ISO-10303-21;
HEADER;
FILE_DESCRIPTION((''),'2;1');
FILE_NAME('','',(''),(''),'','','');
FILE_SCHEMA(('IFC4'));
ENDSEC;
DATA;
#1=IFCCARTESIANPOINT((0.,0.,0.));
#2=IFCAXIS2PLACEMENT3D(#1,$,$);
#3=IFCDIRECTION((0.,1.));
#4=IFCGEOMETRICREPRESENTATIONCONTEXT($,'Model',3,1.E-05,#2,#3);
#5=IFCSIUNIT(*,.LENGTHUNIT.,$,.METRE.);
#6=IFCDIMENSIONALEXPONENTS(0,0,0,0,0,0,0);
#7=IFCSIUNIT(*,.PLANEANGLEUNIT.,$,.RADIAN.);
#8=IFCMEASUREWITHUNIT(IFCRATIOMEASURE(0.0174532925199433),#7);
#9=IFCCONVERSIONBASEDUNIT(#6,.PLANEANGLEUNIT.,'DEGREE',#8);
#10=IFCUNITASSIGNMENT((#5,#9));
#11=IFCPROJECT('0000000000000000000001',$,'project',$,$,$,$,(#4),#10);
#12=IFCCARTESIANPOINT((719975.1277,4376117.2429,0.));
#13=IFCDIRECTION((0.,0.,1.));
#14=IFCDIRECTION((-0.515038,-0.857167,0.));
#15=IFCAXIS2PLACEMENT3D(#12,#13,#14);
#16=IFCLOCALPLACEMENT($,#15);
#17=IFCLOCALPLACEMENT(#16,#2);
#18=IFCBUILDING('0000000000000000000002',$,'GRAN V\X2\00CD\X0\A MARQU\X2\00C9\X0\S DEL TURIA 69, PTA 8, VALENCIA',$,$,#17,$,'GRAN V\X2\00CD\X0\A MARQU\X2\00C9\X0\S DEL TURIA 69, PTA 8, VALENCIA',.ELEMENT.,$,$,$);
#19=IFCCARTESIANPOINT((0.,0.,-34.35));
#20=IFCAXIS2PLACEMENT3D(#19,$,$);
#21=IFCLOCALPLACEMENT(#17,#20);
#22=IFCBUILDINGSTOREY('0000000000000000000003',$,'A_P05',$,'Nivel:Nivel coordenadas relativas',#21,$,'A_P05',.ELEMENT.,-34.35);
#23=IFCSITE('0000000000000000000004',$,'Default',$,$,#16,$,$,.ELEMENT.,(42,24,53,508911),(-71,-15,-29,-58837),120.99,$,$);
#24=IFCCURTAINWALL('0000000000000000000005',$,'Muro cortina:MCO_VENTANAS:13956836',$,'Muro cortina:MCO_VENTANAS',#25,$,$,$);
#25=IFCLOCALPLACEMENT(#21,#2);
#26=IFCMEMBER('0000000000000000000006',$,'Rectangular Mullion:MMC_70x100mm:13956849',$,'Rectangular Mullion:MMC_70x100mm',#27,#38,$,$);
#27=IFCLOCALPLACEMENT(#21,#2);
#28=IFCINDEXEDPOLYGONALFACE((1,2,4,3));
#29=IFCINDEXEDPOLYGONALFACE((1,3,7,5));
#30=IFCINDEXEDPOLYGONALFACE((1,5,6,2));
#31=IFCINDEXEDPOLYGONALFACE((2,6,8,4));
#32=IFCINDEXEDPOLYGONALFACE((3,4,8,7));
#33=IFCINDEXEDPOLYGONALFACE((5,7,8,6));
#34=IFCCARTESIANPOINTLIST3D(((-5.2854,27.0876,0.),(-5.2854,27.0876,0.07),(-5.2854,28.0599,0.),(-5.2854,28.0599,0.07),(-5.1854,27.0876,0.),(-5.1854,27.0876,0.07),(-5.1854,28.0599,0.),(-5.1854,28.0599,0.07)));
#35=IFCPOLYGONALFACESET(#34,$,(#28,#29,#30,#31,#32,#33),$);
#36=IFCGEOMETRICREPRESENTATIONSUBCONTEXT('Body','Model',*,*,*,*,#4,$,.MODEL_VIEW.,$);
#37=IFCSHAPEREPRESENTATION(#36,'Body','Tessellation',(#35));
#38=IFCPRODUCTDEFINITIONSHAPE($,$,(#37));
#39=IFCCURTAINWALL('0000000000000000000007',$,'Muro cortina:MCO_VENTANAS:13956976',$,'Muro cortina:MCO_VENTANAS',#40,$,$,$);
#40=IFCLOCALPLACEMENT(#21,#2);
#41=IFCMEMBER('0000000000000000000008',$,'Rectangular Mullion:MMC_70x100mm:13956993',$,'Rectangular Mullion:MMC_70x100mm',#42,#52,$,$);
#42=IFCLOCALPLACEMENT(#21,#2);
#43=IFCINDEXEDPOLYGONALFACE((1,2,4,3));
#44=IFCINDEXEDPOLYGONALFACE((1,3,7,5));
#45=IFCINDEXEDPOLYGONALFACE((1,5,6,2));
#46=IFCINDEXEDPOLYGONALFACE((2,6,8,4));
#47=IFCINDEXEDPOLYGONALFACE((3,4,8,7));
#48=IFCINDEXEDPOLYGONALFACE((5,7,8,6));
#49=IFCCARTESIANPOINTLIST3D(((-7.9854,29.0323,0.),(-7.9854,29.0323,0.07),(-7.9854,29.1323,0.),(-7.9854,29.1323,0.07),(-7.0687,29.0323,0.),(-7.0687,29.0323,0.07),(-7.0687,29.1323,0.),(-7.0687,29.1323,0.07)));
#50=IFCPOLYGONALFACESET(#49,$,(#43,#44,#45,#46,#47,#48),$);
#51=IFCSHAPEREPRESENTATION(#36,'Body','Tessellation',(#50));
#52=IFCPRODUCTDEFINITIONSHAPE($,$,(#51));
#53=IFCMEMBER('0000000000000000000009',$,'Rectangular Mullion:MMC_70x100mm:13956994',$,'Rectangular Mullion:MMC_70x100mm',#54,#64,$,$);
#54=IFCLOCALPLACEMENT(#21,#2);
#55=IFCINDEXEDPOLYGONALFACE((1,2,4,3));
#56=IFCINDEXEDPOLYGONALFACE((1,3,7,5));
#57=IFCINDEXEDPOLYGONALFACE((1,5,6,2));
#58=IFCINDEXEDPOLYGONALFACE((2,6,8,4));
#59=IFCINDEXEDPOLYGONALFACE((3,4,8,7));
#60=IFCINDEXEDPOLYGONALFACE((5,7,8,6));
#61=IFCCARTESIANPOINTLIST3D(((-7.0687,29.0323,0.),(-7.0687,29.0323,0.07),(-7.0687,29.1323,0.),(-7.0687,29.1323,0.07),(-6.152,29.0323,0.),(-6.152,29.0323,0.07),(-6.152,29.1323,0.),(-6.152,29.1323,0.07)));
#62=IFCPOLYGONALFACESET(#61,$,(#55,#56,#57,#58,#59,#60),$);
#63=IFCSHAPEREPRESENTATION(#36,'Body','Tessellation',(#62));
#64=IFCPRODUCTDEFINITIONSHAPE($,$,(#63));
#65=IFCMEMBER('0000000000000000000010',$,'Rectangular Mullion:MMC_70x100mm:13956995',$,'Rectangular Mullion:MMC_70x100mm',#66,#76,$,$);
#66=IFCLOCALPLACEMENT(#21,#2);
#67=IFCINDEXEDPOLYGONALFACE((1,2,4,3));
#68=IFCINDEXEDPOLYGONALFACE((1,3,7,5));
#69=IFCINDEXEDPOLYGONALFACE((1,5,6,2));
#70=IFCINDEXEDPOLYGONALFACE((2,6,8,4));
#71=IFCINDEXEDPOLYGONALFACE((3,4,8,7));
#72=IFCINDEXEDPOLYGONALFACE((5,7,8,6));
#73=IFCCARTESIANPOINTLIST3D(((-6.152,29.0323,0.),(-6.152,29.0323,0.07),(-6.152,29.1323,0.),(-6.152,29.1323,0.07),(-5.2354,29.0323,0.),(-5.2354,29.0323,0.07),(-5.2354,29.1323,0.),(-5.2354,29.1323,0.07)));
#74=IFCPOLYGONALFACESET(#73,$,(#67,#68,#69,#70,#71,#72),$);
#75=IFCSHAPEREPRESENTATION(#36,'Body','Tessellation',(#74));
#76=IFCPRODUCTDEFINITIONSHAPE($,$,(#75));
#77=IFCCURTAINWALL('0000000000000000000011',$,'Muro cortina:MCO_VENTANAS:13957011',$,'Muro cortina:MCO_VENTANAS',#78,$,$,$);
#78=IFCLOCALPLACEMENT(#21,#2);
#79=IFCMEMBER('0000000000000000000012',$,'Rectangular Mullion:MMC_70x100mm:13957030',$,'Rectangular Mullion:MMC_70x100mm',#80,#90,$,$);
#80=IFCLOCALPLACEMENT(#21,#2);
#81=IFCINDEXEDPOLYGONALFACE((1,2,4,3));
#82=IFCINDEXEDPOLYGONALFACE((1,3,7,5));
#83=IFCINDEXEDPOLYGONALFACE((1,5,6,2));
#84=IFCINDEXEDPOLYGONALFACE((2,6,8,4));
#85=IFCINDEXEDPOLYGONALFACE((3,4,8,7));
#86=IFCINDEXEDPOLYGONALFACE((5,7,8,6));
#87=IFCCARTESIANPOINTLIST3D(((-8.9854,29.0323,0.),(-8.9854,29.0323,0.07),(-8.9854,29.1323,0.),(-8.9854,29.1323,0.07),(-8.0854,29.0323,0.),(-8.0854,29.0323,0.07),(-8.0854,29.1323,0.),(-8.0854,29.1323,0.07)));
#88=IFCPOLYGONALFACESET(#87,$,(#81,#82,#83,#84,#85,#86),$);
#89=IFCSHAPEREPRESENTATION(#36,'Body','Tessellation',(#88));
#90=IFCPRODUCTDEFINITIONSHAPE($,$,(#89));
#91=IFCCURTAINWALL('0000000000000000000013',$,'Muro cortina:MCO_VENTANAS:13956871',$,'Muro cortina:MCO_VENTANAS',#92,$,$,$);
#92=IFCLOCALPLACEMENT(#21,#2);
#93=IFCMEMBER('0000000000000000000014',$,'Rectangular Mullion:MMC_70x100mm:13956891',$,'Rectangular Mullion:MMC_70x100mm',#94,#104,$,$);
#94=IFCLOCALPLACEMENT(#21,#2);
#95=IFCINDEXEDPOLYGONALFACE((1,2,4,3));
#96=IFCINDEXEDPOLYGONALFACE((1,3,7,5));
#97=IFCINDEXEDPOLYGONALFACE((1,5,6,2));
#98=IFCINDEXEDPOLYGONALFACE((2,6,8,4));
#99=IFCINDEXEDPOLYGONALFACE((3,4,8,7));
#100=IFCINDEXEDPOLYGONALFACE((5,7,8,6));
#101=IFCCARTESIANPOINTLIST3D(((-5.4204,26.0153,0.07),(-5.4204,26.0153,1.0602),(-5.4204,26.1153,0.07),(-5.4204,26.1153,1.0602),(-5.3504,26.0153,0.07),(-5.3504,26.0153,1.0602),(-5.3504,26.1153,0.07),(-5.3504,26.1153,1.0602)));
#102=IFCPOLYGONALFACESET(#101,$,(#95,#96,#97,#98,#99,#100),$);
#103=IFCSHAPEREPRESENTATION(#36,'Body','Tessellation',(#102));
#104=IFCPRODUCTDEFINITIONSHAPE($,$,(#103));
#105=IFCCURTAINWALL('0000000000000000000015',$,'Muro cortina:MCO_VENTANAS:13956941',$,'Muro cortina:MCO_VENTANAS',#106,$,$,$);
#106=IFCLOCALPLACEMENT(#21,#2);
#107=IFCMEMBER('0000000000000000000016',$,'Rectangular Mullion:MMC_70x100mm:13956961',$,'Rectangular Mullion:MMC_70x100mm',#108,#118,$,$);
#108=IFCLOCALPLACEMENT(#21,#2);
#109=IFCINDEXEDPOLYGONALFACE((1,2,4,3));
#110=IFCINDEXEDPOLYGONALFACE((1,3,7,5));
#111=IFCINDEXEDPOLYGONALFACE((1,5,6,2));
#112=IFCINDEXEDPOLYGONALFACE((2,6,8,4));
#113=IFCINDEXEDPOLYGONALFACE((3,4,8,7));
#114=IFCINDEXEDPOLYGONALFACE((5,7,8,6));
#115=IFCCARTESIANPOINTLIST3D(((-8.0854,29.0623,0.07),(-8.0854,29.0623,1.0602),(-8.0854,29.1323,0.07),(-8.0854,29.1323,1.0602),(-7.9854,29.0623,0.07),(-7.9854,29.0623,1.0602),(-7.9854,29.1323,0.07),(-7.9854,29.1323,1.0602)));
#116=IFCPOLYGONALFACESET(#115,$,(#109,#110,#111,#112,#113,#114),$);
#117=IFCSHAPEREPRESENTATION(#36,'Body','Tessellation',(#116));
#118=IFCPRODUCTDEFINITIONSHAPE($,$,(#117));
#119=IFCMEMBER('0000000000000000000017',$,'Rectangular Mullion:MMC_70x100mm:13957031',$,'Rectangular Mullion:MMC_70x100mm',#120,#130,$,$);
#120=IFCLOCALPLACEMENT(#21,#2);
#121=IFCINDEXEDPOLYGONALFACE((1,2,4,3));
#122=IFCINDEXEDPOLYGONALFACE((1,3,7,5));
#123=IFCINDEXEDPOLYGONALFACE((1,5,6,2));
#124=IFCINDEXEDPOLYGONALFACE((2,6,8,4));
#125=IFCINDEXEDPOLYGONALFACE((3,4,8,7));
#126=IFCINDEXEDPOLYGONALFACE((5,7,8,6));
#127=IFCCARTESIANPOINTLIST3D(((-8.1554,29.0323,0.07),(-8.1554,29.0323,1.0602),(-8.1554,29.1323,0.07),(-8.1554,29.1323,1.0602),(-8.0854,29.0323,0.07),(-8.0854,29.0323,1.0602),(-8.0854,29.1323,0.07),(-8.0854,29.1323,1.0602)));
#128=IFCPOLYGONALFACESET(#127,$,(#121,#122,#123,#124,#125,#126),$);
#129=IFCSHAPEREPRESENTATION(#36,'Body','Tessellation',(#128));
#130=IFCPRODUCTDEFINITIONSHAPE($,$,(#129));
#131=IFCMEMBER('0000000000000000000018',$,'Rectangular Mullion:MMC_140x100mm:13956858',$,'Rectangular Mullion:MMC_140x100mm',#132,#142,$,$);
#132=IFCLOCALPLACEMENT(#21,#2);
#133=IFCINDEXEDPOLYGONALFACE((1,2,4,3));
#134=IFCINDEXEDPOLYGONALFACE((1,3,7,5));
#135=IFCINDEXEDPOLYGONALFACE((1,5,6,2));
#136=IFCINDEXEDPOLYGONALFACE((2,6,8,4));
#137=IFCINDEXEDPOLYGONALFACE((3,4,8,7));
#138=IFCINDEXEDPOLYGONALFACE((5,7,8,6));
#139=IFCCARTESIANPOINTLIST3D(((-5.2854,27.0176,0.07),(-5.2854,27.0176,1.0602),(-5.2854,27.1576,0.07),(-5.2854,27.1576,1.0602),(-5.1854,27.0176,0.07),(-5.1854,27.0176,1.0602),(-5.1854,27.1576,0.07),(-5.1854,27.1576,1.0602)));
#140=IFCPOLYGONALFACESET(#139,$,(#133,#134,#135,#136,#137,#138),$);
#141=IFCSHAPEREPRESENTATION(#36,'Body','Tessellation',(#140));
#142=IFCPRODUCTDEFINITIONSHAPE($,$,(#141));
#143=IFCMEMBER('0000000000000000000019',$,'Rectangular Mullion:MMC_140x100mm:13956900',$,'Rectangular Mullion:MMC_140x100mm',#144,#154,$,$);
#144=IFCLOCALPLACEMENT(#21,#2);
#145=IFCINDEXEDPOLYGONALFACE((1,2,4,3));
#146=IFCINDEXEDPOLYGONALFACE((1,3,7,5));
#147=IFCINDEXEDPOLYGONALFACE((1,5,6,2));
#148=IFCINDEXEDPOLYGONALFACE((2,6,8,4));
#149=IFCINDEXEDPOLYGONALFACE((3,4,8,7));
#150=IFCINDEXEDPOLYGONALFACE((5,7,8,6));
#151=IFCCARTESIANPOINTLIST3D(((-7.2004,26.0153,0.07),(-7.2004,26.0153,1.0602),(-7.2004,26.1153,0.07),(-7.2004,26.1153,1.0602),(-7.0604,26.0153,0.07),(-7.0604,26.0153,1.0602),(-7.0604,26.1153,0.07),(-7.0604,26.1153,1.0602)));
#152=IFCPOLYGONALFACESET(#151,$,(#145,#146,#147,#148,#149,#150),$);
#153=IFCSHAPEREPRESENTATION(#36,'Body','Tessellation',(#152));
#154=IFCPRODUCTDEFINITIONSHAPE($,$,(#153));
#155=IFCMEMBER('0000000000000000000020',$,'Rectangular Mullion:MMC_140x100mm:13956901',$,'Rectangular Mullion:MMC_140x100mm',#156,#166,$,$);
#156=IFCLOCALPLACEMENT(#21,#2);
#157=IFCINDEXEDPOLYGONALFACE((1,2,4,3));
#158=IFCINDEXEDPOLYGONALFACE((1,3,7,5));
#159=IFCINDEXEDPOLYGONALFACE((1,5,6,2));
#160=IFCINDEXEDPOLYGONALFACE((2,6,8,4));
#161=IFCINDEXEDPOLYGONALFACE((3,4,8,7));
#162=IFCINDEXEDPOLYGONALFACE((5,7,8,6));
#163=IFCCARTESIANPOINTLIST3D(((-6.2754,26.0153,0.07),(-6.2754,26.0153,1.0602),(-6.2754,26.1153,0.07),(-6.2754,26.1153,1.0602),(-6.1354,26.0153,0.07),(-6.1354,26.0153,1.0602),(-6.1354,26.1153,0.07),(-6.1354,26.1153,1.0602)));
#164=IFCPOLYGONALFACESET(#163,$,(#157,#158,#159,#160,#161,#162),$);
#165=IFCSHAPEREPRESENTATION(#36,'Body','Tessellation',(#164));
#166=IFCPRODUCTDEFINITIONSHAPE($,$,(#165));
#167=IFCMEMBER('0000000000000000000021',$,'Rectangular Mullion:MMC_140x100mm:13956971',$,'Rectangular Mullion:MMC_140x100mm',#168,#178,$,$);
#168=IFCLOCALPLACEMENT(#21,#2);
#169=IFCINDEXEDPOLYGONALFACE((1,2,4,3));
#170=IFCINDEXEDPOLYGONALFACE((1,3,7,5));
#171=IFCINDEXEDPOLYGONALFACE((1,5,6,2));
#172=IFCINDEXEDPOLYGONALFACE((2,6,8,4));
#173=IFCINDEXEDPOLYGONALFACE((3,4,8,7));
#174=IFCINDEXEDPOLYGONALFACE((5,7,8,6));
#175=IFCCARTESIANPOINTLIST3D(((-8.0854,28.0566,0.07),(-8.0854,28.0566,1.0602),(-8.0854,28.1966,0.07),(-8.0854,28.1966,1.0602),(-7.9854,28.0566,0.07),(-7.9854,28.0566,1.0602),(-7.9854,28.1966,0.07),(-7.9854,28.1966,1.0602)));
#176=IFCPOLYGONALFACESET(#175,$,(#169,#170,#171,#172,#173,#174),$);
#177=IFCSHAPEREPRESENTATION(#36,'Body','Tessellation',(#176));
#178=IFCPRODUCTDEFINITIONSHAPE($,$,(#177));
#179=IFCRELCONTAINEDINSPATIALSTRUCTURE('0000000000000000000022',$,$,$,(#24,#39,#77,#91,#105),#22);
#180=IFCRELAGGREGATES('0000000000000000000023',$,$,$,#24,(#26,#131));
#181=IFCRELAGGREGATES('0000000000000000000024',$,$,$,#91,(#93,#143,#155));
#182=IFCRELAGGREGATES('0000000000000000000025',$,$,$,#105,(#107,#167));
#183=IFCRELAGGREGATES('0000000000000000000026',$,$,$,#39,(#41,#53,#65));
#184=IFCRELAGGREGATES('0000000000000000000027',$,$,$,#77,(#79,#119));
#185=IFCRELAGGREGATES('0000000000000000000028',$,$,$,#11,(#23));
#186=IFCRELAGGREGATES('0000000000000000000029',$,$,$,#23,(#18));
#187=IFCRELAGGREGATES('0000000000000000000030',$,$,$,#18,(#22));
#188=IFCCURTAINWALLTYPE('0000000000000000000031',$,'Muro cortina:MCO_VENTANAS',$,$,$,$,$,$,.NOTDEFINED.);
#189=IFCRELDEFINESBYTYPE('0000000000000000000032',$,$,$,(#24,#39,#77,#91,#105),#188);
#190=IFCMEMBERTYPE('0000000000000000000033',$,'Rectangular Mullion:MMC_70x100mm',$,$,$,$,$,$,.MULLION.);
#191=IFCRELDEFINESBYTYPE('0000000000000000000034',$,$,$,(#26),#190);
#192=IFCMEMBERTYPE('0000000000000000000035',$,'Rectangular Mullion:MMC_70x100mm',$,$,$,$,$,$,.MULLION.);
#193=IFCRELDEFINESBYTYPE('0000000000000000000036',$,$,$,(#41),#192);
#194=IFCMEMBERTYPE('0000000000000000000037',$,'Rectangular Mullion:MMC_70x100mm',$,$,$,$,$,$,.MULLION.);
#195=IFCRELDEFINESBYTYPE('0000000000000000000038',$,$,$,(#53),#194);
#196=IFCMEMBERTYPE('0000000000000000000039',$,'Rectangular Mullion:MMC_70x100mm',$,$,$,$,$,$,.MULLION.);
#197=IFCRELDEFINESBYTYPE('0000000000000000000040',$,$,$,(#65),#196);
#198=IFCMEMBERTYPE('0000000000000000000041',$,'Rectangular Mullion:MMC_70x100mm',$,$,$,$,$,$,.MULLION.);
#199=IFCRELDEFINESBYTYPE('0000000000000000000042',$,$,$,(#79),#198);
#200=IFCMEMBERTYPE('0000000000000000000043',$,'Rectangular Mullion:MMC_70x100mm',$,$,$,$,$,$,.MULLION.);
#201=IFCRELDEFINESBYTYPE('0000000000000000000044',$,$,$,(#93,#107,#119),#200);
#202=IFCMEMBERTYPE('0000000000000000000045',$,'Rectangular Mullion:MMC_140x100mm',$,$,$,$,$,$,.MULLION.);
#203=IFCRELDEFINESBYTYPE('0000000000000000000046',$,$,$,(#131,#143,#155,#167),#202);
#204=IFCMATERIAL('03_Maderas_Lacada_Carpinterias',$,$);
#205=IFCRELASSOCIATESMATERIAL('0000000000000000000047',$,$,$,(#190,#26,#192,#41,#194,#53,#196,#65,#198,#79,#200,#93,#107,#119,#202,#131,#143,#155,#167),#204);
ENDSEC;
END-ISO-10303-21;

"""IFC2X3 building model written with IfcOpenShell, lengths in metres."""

from ifc_helpers import new_model, entity, si_unit, converted_unit, direction, frame, origin, origin_2d_with_axis, place, context, subcontext, project, spatial, rectangle, extrude, source, transform, mapped, material, type_object, type_shapes, element, aggregate, save


model = new_model("IFC2X3")

# Units and contexts
model_context = context("Model", 3, precision=1e-05, world=origin(), true_north=direction((0.0, 1.0)))
body_context = subcontext(model_context, "Body", "Model", "MODEL_VIEW")
ifc_project = project(units=[si_unit("LENGTHUNIT", "METRE"), converted_unit("PLANEANGLEUNIT", "DEGREE", entity("IfcRatioMeasure", 0.0174532925199433), si_unit("PLANEANGLEUNIT", "RADIAN"), dimensions=[0, 0, 0, 0, 0, 0, 0])], contexts=[model_context])

# Site, building, storey
site_placement = place(None, frame((719975.1277, 4376117.2429, 0.0), z_axis=(0.0, 0.0, 1.0), x_axis=(-0.515038, -0.857167, 0.0)))
site = spatial("IfcSite", under=ifc_project, at=site_placement, Name="Default", CompositionType="ELEMENT", RefLatitude=(42, 24, 53, 508911), RefLongitude=(-71, -15, -29, -58837), RefElevation=120.99)
building_placement = place(site_placement, origin())
building = spatial("IfcBuilding", under=site, at=building_placement, Name="GRAN VÍA MARQUÉS DEL TURIA 69, PTA 8, VALENCIA", LongName="GRAN VÍA MARQUÉS DEL TURIA 69, PTA 8, VALENCIA", CompositionType="ELEMENT")
storey_placement = place(building_placement, frame((0.0, 0.0, -34.35)))
storey = spatial("IfcBuildingStorey", under=building, at=storey_placement, Name="A_P05", ObjectType="Nivel:Nivel coordenadas relativas", LongName="A_P05", CompositionType="ELEMENT", Elevation=-34.35)

# Curtain wall, member
curtain_wall_type = type_object("IfcCurtainWallType", Name="Muro cortina:MCO_VENTANAS", PredefinedType="NOTDEFINED")
curtain_wall_1_placement = place(storey_placement, frame((0.0, 0.0, 34.35)))
curtain_wall_1 = element("IfcCurtainWall", 1, at=curtain_wall_1_placement, inside=storey, type_object=curtain_wall_type, Name="Muro cortina:MCO_VENTANAS:13956836", ObjectType="Muro cortina:MCO_VENTANAS")
ifc_material_1 = material(Name="03_Maderas_Lacada_Carpinterias")
member_type_1 = type_object("IfcMemberType", Name="Rectangular Mullion:MMC_70x100mm", PredefinedType="MULLION", material=ifc_material_1)
shared_shape_1 = source(origin(), body_context, "Body", "SweptSolid", [
    extrude(rectangle(XDim=0.1, YDim=0.07, at=origin_2d_with_axis()), frame((-0.035, 0.0, -0.9723), z_axis=(0.0, 0.0, 1.0), x_axis=(0.0, -1.0, 0.0)), (0.0, 0.0, 1.0), 0.9723),
])
type_shapes(member_type_1, [shared_shape_1])
member_1_placement = place(storey_placement, frame((-5.2354, 27.0876, 0.0), z_axis=(0.0, -1.0, 0.0), x_axis=(0.0, 0.0, -1.0)))
member_1 = element("IfcMember", 2, at=member_1_placement, type_object=member_type_1, material=ifc_material_1, Name="Rectangular Mullion:MMC_70x100mm:13956849", ObjectType="Rectangular Mullion:MMC_70x100mm", context=body_context, shape_type="MappedRepresentation", body=[
    mapped(shared_shape_1, transform((0.0, 0.0, 0.0), scale=1.0)),
])

# Curtain wall, members
curtain_wall_2_placement = place(storey_placement, frame((0.0, 0.0, 34.35)))
curtain_wall_2 = element("IfcCurtainWall", 3, at=curtain_wall_2_placement, inside=storey, type_object=curtain_wall_type, Name="Muro cortina:MCO_VENTANAS:13956976", ObjectType="Muro cortina:MCO_VENTANAS")
member_type_2 = type_object("IfcMemberType", Name="Rectangular Mullion:MMC_70x100mm", PredefinedType="MULLION", material=ifc_material_1)
shared_shape_2 = source(origin(), body_context, "Body", "SweptSolid", [
    extrude(rectangle(XDim=0.1, YDim=0.07, at=origin_2d_with_axis()), frame((-0.035, 0.0, -0.9167), z_axis=(0.0, 0.0, 1.0), x_axis=(0.0, -1.0, 0.0)), (0.0, 0.0, 1.0), 0.9167),
])
type_shapes(member_type_2, [shared_shape_2])
member_2_placement = place(storey_placement, frame((-7.9854, 29.0823, 0.0), z_axis=(-1.0, 0.0, 0.0), x_axis=(0.0, 0.0, -1.0)))
member_2 = element("IfcMember", 4, at=member_2_placement, type_object=member_type_2, material=ifc_material_1, Name="Rectangular Mullion:MMC_70x100mm:13956993", ObjectType="Rectangular Mullion:MMC_70x100mm", context=body_context, shape_type="MappedRepresentation", body=[
    mapped(shared_shape_2, transform((0.0, 0.0, 0.0), scale=1.0)),
])
member_type_3 = type_object("IfcMemberType", Name="Rectangular Mullion:MMC_70x100mm", PredefinedType="MULLION", material=ifc_material_1)
shared_shape_3 = source(origin(), body_context, "Body", "SweptSolid", [
    extrude(rectangle(XDim=0.1, YDim=0.07, at=origin_2d_with_axis()), frame((-0.035, 0.0, -0.9167), z_axis=(0.0, 0.0, 1.0), x_axis=(0.0, -1.0, 0.0)), (0.0, 0.0, 1.0), 0.9167),
])
type_shapes(member_type_3, [shared_shape_3])
member_3_placement = place(storey_placement, frame((-7.0687, 29.0823, 0.0), z_axis=(-1.0, 0.0, 0.0), x_axis=(0.0, 0.0, -1.0)))
member_3 = element("IfcMember", 5, at=member_3_placement, type_object=member_type_3, material=ifc_material_1, Name="Rectangular Mullion:MMC_70x100mm:13956994", ObjectType="Rectangular Mullion:MMC_70x100mm", context=body_context, shape_type="MappedRepresentation", body=[
    mapped(shared_shape_3, transform((0.0, 0.0, 0.0), scale=1.0)),
])
member_type_4 = type_object("IfcMemberType", Name="Rectangular Mullion:MMC_70x100mm", PredefinedType="MULLION", material=ifc_material_1)
shared_shape_4 = source(origin(), body_context, "Body", "SweptSolid", [
    extrude(rectangle(XDim=0.1, YDim=0.07, at=origin_2d_with_axis()), frame((-0.035, 0.0, -0.9167), z_axis=(0.0, 0.0, 1.0), x_axis=(0.0, -1.0, 0.0)), (0.0, 0.0, 1.0), 0.9167),
])
type_shapes(member_type_4, [shared_shape_4])
member_4_placement = place(storey_placement, frame((-6.152, 29.0823, 0.0), z_axis=(-1.0, 0.0, 0.0), x_axis=(0.0, 0.0, -1.0)))
member_4 = element("IfcMember", 6, at=member_4_placement, type_object=member_type_4, material=ifc_material_1, Name="Rectangular Mullion:MMC_70x100mm:13956995", ObjectType="Rectangular Mullion:MMC_70x100mm", context=body_context, shape_type="MappedRepresentation", body=[
    mapped(shared_shape_4, transform((0.0, 0.0, 0.0), scale=1.0)),
])

# Curtain walls, members
curtain_wall_3_placement = place(storey_placement, frame((0.0, 0.0, 34.35)))
curtain_wall_3 = element("IfcCurtainWall", 7, at=curtain_wall_3_placement, inside=storey, type_object=curtain_wall_type, Name="Muro cortina:MCO_VENTANAS:13957011", ObjectType="Muro cortina:MCO_VENTANAS")
member_type_5 = type_object("IfcMemberType", Name="Rectangular Mullion:MMC_70x100mm", PredefinedType="MULLION", material=ifc_material_1)
shared_shape_5 = source(origin(), body_context, "Body", "SweptSolid", [
    extrude(rectangle(XDim=0.1, YDim=0.07, at=origin_2d_with_axis()), frame((-0.035, 0.0, -0.9), z_axis=(0.0, 0.0, 1.0), x_axis=(0.0, -1.0, 0.0)), (0.0, 0.0, 1.0), 0.9),
])
type_shapes(member_type_5, [shared_shape_5])
member_5_placement = place(storey_placement, frame((-8.9854, 29.0823, 0.0), z_axis=(-1.0, 0.0, 0.0), x_axis=(0.0, 0.0, -1.0)))
member_5 = element("IfcMember", 8, at=member_5_placement, type_object=member_type_5, material=ifc_material_1, Name="Rectangular Mullion:MMC_70x100mm:13957030", ObjectType="Rectangular Mullion:MMC_70x100mm", context=body_context, shape_type="MappedRepresentation", body=[
    mapped(shared_shape_5, transform((0.0, 0.0, 0.0), scale=1.0)),
])
curtain_wall_4_placement = place(storey_placement, frame((0.0, 0.0, 34.35)))
curtain_wall_4 = element("IfcCurtainWall", 9, at=curtain_wall_4_placement, inside=storey, type_object=curtain_wall_type, Name="Muro cortina:MCO_VENTANAS:13956871", ObjectType="Muro cortina:MCO_VENTANAS")
member_type_6 = type_object("IfcMemberType", Name="Rectangular Mullion:MMC_70x100mm", PredefinedType="MULLION", material=ifc_material_1)
shared_shape_6 = source(origin(), body_context, "Body", "SweptSolid", [
    extrude(rectangle(XDim=0.1, YDim=0.07, at=origin_2d_with_axis()), frame((-0.035, 0.0, -0.9902), z_axis=(0.0, 0.0, 1.0), x_axis=(0.0, -1.0, 0.0)), (0.0, 0.0, 1.0), 0.9902),
])
type_shapes(member_type_6, [shared_shape_6])
member_6_placement = place(storey_placement, frame((-5.3504, 26.0653, 0.07), z_axis=(0.0, 0.0, -1.0), x_axis=(1.0, 0.0, 0.0)))
member_6 = element("IfcMember", 10, at=member_6_placement, type_object=member_type_6, material=ifc_material_1, Name="Rectangular Mullion:MMC_70x100mm:13956891", ObjectType="Rectangular Mullion:MMC_70x100mm", context=body_context, shape_type="MappedRepresentation", body=[
    mapped(shared_shape_6, transform((0.0, 0.0, 0.0), scale=1.0)),
])
curtain_wall_5_placement = place(storey_placement, frame((0.0, 0.0, 34.35)))
curtain_wall_5 = element("IfcCurtainWall", 11, at=curtain_wall_5_placement, inside=storey, type_object=curtain_wall_type, Name="Muro cortina:MCO_VENTANAS:13956941", ObjectType="Muro cortina:MCO_VENTANAS")
member_7_placement = place(storey_placement, frame((-8.0354, 29.1323, 0.07), z_axis=(0.0, 0.0, -1.0), x_axis=(0.0, 1.0, 0.0)))
member_7 = element("IfcMember", 12, at=member_7_placement, type_object=member_type_6, material=ifc_material_1, Name="Rectangular Mullion:MMC_70x100mm:13956961", ObjectType="Rectangular Mullion:MMC_70x100mm", context=body_context, shape_type="MappedRepresentation", body=[
    mapped(shared_shape_6, transform((0.0, 0.0, 0.0), scale=1.0)),
])

# Members
member_8_placement = place(storey_placement, frame((-8.0854, 29.0823, 0.07), z_axis=(0.0, 0.0, -1.0), x_axis=(1.0, 0.0, 0.0)))
member_8 = element("IfcMember", 13, at=member_8_placement, type_object=member_type_6, material=ifc_material_1, Name="Rectangular Mullion:MMC_70x100mm:13957031", ObjectType="Rectangular Mullion:MMC_70x100mm", context=body_context, shape_type="MappedRepresentation", body=[
    mapped(shared_shape_6, transform((0.0, 0.0, 0.0), scale=1.0)),
])
member_type_7 = type_object("IfcMemberType", Name="Rectangular Mullion:MMC_140x100mm", PredefinedType="MULLION", material=ifc_material_1)
shared_shape_7 = source(origin(), body_context, "Body", "SweptSolid", [
    extrude(rectangle(XDim=0.1, YDim=0.14, at=origin_2d_with_axis()), frame((0.0, 0.0, -0.9902), z_axis=(0.0, 0.0, 1.0), x_axis=(0.0, -1.0, 0.0)), (0.0, 0.0, 1.0), 0.9902),
])
type_shapes(member_type_7, [shared_shape_7])
member_9_placement = place(storey_placement, frame((-5.2354, 27.0876, 0.07), z_axis=(0.0, 0.0, -1.0), x_axis=(0.0, 1.0, 0.0)))
member_9 = element("IfcMember", 14, at=member_9_placement, type_object=member_type_7, material=ifc_material_1, Name="Rectangular Mullion:MMC_140x100mm:13956858", ObjectType="Rectangular Mullion:MMC_140x100mm", context=body_context, shape_type="MappedRepresentation", body=[
    mapped(shared_shape_7, transform((0.0, 0.0, 0.0), scale=1.0)),
])
member_10_placement = place(storey_placement, frame((-7.1304, 26.0653, 0.07), z_axis=(0.0, 0.0, -1.0), x_axis=(1.0, 0.0, 0.0)))
member_10 = element("IfcMember", 15, at=member_10_placement, type_object=member_type_7, material=ifc_material_1, Name="Rectangular Mullion:MMC_140x100mm:13956900", ObjectType="Rectangular Mullion:MMC_140x100mm", context=body_context, shape_type="MappedRepresentation", body=[
    mapped(shared_shape_7, transform((0.0, 0.0, 0.0), scale=1.0)),
])
member_11_placement = place(storey_placement, frame((-6.2054, 26.0653, 0.07), z_axis=(0.0, 0.0, -1.0), x_axis=(1.0, 0.0, 0.0)))
member_11 = element("IfcMember", 16, at=member_11_placement, type_object=member_type_7, material=ifc_material_1, Name="Rectangular Mullion:MMC_140x100mm:13956901", ObjectType="Rectangular Mullion:MMC_140x100mm", context=body_context, shape_type="MappedRepresentation", body=[
    mapped(shared_shape_7, transform((0.0, 0.0, 0.0), scale=1.0)),
])
member_12_placement = place(storey_placement, frame((-8.0354, 28.1266, 0.07), z_axis=(0.0, 0.0, -1.0), x_axis=(0.0, 1.0, 0.0)))
member_12 = element("IfcMember", 17, at=member_12_placement, type_object=member_type_7, material=ifc_material_1, Name="Rectangular Mullion:MMC_140x100mm:13956971", ObjectType="Rectangular Mullion:MMC_140x100mm", context=body_context, shape_type="MappedRepresentation", body=[
    mapped(shared_shape_7, transform((0.0, 0.0, 0.0), scale=1.0)),
])

aggregate(curtain_wall_1, [member_1, member_9])
aggregate(curtain_wall_4, [member_6, member_10, member_11])
aggregate(curtain_wall_5, [member_7, member_12])
aggregate(curtain_wall_2, [member_2, member_3, member_4])
aggregate(curtain_wall_3, [member_5, member_8])

save(model, "model.ifc")
